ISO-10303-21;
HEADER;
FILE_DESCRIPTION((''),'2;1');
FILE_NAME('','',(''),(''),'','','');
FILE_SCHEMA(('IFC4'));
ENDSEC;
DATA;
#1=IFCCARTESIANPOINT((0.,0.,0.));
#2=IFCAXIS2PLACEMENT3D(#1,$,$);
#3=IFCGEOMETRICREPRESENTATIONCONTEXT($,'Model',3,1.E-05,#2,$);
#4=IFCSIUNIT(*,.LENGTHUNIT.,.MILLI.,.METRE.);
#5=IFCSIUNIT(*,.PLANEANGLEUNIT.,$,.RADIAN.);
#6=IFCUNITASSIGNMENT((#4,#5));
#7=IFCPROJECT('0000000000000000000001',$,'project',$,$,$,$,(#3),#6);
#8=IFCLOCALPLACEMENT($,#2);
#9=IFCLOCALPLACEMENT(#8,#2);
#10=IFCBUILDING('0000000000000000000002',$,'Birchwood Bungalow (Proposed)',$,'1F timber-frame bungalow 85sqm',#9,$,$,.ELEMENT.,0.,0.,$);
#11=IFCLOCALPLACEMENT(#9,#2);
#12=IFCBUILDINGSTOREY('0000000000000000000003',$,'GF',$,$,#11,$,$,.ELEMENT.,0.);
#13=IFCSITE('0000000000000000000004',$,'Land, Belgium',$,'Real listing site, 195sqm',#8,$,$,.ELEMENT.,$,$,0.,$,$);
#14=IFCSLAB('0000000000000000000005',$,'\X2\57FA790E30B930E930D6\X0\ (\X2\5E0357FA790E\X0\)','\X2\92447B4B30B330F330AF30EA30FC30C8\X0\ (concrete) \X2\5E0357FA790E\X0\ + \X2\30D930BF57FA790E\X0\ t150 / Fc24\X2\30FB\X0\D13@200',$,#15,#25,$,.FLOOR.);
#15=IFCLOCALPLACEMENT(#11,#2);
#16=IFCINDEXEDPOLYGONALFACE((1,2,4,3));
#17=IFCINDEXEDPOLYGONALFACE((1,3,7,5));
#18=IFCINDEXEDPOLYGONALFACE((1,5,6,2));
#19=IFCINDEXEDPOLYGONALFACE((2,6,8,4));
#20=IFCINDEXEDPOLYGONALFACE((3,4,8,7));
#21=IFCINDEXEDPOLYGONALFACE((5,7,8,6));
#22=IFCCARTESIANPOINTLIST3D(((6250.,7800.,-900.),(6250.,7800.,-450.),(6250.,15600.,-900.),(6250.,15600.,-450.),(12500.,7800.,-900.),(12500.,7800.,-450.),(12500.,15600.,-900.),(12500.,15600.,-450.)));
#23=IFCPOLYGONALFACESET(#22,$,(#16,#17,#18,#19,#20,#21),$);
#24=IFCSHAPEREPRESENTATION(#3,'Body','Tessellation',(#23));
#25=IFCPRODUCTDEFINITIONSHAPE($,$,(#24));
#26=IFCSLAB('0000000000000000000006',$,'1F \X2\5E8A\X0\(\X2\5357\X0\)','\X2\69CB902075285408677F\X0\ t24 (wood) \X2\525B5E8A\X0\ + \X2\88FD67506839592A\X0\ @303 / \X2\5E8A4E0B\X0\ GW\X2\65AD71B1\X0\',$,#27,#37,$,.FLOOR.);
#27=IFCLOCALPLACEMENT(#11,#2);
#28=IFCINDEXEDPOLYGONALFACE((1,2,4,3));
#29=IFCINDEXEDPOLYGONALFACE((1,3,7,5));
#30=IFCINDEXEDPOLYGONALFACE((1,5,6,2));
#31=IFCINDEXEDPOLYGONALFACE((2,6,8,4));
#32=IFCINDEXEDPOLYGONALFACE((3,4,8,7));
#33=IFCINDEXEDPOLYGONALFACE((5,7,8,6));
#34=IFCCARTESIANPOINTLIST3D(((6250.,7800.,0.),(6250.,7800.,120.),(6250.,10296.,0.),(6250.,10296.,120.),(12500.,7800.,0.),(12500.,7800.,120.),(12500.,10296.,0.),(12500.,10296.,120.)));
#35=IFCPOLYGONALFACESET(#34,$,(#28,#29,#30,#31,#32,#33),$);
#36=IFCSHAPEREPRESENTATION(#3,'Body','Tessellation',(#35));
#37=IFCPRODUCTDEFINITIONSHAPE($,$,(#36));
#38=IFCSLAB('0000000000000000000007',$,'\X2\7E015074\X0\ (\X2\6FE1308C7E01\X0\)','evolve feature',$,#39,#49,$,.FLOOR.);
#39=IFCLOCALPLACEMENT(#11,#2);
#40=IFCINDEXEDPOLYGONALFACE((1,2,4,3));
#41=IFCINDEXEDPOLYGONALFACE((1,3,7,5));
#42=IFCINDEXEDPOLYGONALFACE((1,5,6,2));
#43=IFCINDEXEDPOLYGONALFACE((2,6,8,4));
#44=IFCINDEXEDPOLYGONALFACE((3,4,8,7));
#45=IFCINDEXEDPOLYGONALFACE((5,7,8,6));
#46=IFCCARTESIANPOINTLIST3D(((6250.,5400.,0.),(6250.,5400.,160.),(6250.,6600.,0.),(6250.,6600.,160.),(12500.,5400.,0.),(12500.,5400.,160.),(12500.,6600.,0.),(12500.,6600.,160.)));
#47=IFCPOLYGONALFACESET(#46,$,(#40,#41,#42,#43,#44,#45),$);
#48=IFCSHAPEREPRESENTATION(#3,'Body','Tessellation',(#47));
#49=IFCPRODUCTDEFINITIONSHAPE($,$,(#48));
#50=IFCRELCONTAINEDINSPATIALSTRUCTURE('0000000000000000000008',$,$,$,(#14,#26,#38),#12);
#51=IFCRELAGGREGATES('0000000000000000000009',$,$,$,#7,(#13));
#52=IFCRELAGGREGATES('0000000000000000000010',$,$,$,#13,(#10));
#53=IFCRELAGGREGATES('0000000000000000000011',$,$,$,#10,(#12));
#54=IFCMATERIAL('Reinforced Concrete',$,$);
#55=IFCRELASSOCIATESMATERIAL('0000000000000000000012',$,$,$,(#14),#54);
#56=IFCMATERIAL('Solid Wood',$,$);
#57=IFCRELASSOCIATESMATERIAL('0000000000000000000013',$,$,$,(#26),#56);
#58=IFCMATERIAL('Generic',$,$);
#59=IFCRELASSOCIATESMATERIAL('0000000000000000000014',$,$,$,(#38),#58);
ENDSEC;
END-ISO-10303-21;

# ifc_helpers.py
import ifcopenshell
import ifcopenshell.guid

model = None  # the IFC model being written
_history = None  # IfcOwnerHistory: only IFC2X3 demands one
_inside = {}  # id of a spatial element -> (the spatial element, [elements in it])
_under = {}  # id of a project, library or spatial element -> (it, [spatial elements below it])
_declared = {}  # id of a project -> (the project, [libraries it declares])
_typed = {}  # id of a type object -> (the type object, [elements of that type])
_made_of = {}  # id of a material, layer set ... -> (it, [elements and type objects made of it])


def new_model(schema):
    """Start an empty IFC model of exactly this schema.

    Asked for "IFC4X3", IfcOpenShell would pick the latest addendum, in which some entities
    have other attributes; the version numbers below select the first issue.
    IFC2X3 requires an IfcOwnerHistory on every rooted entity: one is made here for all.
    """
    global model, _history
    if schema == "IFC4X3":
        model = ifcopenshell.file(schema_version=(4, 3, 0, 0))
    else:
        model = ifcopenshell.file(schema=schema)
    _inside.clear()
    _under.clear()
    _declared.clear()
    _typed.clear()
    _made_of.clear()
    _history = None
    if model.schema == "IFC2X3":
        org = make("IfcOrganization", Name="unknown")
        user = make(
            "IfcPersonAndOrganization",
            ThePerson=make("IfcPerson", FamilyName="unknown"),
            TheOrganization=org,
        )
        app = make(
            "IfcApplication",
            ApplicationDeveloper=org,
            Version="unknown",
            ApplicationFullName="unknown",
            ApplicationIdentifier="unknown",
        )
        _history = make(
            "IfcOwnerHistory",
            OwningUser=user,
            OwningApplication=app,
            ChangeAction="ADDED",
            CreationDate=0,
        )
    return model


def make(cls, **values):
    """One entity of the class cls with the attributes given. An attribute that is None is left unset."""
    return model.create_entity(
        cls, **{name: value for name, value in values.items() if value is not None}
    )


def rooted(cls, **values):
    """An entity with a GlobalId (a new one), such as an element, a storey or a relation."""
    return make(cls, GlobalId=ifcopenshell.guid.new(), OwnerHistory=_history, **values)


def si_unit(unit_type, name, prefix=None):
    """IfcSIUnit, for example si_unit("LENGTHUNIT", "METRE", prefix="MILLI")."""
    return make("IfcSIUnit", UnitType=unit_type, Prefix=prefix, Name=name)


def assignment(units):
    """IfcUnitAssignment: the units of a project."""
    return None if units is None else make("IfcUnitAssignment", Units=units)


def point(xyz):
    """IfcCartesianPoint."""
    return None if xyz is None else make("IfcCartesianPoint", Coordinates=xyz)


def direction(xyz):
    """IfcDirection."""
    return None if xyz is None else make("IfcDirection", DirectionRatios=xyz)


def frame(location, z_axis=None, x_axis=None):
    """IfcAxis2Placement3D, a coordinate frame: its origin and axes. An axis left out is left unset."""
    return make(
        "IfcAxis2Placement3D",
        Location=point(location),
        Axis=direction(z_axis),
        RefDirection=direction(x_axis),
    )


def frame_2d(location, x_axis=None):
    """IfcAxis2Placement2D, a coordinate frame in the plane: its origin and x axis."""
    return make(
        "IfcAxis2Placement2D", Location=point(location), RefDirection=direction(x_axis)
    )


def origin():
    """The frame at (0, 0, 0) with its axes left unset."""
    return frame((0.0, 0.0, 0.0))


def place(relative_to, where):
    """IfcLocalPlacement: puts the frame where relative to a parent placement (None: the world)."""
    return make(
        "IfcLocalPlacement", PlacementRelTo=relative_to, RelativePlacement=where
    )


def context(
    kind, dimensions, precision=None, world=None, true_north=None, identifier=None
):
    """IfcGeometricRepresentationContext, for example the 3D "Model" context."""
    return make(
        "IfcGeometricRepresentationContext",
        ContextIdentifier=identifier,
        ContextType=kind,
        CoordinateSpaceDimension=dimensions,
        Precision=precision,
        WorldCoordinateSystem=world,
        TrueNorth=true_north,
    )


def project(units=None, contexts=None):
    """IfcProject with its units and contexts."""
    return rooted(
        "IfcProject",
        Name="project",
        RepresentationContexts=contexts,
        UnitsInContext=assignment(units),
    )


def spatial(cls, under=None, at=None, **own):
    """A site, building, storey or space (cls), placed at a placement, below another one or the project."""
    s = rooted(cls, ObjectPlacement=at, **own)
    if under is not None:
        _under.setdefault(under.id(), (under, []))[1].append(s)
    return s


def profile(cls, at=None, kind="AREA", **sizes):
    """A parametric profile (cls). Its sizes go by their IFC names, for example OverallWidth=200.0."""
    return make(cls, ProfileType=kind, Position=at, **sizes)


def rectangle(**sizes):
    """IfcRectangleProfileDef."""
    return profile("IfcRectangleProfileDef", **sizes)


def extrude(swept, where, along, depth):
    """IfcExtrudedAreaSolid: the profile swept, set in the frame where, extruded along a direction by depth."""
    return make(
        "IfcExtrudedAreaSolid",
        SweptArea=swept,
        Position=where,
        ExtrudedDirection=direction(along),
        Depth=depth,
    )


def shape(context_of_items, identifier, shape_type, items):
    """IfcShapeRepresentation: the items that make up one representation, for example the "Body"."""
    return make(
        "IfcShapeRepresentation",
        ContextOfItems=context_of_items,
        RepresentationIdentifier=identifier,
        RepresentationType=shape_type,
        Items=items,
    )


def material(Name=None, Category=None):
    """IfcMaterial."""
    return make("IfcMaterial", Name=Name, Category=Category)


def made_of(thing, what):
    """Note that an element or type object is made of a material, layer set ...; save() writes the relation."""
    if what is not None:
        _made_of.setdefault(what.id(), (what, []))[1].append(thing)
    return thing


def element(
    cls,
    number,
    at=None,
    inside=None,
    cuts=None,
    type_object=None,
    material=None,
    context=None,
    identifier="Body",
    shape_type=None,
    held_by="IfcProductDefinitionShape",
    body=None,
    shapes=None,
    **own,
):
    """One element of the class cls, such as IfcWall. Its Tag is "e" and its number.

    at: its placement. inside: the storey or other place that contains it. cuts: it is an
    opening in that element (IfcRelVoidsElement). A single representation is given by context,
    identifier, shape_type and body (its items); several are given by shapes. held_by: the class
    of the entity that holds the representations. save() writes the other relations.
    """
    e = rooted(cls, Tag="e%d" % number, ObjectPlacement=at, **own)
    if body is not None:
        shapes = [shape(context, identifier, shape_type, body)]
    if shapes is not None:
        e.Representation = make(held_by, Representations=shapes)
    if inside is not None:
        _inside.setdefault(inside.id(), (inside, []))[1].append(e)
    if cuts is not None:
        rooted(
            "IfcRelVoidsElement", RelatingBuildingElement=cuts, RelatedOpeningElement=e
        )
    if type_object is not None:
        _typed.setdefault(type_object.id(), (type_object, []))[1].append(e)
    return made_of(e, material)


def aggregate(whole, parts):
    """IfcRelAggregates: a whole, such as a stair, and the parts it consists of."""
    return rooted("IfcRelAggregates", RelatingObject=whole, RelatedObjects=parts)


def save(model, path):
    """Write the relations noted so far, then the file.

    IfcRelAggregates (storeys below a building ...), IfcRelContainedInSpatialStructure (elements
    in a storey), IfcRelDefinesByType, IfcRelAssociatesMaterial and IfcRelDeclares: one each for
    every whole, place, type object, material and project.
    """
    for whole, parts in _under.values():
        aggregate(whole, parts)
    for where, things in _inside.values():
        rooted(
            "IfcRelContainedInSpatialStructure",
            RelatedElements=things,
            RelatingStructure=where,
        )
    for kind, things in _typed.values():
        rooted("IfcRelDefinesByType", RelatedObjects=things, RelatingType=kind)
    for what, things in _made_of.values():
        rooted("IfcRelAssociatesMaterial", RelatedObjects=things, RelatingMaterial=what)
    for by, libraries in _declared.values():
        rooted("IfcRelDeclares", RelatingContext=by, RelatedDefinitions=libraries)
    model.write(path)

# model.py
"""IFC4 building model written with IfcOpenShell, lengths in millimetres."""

from ifc_helpers import new_model, si_unit, frame, frame_2d, origin, place, context, project, spatial, rectangle, extrude, material, element, save


model = new_model("IFC4")

# Units and contexts
model_context = context("Model", 3, precision=1e-05, world=origin())
ifc_project = project(units=[si_unit("LENGTHUNIT", "METRE", prefix="MILLI"), si_unit("PLANEANGLEUNIT", "RADIAN")], contexts=[model_context])

# Site, building, storey
site_placement = place(None, origin())
site = spatial("IfcSite", under=ifc_project, at=site_placement, Name="Land, Belgium", ObjectType="Real listing site, 195sqm", CompositionType="ELEMENT", RefElevation=0.0)
building_placement = place(site_placement, origin())
building = spatial("IfcBuilding", under=site, at=building_placement, Name="Birchwood Bungalow (Proposed)", ObjectType="1F timber-frame bungalow 85sqm", CompositionType="ELEMENT", ElevationOfRefHeight=0.0, ElevationOfTerrain=0.0)
storey_placement = place(building_placement, origin())
storey = spatial("IfcBuildingStorey", under=building, at=storey_placement, Name="GF", CompositionType="ELEMENT", Elevation=0.0)

# Slabs
ifc_material_1 = material(Name="Reinforced Concrete")
slab_1_placement = place(storey_placement, frame((3125.0, 3900.0, -450.0)))
element("IfcSlab", 1, at=slab_1_placement, inside=storey, material=ifc_material_1, Name="基礎スラブ (布基礎)", Description="鉄筋コンクリート (concrete) 布基礎 + ベタ基礎 t150 / Fc24・D13@200", PredefinedType="FLOOR", context=model_context, shape_type="SweptSolid", body=[
    extrude(rectangle(XDim=6250.0, YDim=7800.0, at=frame_2d((3125.0, 3900.0))), frame((3125.0, 3900.0, -450.0)), (0.0, 0.0, 1.0), 450.0),
])
ifc_material_2 = material(Name="Solid Wood")
slab_2_placement = place(storey_placement, frame((3125.0, 3900.0, 0.0)))
element("IfcSlab", 2, at=slab_2_placement, inside=storey, material=ifc_material_2, Name="1F 床(南)", Description="構造用合板 t24 (wood) 剛床 + 製材根太 @303 / 床下 GW断熱", PredefinedType="FLOOR", context=model_context, shape_type="SweptSolid", body=[
    extrude(rectangle(XDim=6250.0, YDim=2496.0, at=frame_2d((3125.0, 1248.0))), frame((3125.0, 3900.0, 0.0)), (0.0, 0.0, 1.0), 120.0),
])
ifc_material_3 = material(Name="Generic")
slab_3_placement = place(storey_placement, frame((3125.0, 2700.0, 0.0)))
element("IfcSlab", 3, at=slab_3_placement, inside=storey, material=ifc_material_3, Name="縁側 (濡れ縁)", Description="evolve feature", PredefinedType="FLOOR", context=model_context, shape_type="SweptSolid", body=[
    extrude(rectangle(XDim=6250.0, YDim=1200.0, at=frame_2d((3125.0, 600.0))), frame((3125.0, 2700.0, 0.0)), (0.0, 0.0, 1.0), 160.0),
])

save(model, "model.ifc")
